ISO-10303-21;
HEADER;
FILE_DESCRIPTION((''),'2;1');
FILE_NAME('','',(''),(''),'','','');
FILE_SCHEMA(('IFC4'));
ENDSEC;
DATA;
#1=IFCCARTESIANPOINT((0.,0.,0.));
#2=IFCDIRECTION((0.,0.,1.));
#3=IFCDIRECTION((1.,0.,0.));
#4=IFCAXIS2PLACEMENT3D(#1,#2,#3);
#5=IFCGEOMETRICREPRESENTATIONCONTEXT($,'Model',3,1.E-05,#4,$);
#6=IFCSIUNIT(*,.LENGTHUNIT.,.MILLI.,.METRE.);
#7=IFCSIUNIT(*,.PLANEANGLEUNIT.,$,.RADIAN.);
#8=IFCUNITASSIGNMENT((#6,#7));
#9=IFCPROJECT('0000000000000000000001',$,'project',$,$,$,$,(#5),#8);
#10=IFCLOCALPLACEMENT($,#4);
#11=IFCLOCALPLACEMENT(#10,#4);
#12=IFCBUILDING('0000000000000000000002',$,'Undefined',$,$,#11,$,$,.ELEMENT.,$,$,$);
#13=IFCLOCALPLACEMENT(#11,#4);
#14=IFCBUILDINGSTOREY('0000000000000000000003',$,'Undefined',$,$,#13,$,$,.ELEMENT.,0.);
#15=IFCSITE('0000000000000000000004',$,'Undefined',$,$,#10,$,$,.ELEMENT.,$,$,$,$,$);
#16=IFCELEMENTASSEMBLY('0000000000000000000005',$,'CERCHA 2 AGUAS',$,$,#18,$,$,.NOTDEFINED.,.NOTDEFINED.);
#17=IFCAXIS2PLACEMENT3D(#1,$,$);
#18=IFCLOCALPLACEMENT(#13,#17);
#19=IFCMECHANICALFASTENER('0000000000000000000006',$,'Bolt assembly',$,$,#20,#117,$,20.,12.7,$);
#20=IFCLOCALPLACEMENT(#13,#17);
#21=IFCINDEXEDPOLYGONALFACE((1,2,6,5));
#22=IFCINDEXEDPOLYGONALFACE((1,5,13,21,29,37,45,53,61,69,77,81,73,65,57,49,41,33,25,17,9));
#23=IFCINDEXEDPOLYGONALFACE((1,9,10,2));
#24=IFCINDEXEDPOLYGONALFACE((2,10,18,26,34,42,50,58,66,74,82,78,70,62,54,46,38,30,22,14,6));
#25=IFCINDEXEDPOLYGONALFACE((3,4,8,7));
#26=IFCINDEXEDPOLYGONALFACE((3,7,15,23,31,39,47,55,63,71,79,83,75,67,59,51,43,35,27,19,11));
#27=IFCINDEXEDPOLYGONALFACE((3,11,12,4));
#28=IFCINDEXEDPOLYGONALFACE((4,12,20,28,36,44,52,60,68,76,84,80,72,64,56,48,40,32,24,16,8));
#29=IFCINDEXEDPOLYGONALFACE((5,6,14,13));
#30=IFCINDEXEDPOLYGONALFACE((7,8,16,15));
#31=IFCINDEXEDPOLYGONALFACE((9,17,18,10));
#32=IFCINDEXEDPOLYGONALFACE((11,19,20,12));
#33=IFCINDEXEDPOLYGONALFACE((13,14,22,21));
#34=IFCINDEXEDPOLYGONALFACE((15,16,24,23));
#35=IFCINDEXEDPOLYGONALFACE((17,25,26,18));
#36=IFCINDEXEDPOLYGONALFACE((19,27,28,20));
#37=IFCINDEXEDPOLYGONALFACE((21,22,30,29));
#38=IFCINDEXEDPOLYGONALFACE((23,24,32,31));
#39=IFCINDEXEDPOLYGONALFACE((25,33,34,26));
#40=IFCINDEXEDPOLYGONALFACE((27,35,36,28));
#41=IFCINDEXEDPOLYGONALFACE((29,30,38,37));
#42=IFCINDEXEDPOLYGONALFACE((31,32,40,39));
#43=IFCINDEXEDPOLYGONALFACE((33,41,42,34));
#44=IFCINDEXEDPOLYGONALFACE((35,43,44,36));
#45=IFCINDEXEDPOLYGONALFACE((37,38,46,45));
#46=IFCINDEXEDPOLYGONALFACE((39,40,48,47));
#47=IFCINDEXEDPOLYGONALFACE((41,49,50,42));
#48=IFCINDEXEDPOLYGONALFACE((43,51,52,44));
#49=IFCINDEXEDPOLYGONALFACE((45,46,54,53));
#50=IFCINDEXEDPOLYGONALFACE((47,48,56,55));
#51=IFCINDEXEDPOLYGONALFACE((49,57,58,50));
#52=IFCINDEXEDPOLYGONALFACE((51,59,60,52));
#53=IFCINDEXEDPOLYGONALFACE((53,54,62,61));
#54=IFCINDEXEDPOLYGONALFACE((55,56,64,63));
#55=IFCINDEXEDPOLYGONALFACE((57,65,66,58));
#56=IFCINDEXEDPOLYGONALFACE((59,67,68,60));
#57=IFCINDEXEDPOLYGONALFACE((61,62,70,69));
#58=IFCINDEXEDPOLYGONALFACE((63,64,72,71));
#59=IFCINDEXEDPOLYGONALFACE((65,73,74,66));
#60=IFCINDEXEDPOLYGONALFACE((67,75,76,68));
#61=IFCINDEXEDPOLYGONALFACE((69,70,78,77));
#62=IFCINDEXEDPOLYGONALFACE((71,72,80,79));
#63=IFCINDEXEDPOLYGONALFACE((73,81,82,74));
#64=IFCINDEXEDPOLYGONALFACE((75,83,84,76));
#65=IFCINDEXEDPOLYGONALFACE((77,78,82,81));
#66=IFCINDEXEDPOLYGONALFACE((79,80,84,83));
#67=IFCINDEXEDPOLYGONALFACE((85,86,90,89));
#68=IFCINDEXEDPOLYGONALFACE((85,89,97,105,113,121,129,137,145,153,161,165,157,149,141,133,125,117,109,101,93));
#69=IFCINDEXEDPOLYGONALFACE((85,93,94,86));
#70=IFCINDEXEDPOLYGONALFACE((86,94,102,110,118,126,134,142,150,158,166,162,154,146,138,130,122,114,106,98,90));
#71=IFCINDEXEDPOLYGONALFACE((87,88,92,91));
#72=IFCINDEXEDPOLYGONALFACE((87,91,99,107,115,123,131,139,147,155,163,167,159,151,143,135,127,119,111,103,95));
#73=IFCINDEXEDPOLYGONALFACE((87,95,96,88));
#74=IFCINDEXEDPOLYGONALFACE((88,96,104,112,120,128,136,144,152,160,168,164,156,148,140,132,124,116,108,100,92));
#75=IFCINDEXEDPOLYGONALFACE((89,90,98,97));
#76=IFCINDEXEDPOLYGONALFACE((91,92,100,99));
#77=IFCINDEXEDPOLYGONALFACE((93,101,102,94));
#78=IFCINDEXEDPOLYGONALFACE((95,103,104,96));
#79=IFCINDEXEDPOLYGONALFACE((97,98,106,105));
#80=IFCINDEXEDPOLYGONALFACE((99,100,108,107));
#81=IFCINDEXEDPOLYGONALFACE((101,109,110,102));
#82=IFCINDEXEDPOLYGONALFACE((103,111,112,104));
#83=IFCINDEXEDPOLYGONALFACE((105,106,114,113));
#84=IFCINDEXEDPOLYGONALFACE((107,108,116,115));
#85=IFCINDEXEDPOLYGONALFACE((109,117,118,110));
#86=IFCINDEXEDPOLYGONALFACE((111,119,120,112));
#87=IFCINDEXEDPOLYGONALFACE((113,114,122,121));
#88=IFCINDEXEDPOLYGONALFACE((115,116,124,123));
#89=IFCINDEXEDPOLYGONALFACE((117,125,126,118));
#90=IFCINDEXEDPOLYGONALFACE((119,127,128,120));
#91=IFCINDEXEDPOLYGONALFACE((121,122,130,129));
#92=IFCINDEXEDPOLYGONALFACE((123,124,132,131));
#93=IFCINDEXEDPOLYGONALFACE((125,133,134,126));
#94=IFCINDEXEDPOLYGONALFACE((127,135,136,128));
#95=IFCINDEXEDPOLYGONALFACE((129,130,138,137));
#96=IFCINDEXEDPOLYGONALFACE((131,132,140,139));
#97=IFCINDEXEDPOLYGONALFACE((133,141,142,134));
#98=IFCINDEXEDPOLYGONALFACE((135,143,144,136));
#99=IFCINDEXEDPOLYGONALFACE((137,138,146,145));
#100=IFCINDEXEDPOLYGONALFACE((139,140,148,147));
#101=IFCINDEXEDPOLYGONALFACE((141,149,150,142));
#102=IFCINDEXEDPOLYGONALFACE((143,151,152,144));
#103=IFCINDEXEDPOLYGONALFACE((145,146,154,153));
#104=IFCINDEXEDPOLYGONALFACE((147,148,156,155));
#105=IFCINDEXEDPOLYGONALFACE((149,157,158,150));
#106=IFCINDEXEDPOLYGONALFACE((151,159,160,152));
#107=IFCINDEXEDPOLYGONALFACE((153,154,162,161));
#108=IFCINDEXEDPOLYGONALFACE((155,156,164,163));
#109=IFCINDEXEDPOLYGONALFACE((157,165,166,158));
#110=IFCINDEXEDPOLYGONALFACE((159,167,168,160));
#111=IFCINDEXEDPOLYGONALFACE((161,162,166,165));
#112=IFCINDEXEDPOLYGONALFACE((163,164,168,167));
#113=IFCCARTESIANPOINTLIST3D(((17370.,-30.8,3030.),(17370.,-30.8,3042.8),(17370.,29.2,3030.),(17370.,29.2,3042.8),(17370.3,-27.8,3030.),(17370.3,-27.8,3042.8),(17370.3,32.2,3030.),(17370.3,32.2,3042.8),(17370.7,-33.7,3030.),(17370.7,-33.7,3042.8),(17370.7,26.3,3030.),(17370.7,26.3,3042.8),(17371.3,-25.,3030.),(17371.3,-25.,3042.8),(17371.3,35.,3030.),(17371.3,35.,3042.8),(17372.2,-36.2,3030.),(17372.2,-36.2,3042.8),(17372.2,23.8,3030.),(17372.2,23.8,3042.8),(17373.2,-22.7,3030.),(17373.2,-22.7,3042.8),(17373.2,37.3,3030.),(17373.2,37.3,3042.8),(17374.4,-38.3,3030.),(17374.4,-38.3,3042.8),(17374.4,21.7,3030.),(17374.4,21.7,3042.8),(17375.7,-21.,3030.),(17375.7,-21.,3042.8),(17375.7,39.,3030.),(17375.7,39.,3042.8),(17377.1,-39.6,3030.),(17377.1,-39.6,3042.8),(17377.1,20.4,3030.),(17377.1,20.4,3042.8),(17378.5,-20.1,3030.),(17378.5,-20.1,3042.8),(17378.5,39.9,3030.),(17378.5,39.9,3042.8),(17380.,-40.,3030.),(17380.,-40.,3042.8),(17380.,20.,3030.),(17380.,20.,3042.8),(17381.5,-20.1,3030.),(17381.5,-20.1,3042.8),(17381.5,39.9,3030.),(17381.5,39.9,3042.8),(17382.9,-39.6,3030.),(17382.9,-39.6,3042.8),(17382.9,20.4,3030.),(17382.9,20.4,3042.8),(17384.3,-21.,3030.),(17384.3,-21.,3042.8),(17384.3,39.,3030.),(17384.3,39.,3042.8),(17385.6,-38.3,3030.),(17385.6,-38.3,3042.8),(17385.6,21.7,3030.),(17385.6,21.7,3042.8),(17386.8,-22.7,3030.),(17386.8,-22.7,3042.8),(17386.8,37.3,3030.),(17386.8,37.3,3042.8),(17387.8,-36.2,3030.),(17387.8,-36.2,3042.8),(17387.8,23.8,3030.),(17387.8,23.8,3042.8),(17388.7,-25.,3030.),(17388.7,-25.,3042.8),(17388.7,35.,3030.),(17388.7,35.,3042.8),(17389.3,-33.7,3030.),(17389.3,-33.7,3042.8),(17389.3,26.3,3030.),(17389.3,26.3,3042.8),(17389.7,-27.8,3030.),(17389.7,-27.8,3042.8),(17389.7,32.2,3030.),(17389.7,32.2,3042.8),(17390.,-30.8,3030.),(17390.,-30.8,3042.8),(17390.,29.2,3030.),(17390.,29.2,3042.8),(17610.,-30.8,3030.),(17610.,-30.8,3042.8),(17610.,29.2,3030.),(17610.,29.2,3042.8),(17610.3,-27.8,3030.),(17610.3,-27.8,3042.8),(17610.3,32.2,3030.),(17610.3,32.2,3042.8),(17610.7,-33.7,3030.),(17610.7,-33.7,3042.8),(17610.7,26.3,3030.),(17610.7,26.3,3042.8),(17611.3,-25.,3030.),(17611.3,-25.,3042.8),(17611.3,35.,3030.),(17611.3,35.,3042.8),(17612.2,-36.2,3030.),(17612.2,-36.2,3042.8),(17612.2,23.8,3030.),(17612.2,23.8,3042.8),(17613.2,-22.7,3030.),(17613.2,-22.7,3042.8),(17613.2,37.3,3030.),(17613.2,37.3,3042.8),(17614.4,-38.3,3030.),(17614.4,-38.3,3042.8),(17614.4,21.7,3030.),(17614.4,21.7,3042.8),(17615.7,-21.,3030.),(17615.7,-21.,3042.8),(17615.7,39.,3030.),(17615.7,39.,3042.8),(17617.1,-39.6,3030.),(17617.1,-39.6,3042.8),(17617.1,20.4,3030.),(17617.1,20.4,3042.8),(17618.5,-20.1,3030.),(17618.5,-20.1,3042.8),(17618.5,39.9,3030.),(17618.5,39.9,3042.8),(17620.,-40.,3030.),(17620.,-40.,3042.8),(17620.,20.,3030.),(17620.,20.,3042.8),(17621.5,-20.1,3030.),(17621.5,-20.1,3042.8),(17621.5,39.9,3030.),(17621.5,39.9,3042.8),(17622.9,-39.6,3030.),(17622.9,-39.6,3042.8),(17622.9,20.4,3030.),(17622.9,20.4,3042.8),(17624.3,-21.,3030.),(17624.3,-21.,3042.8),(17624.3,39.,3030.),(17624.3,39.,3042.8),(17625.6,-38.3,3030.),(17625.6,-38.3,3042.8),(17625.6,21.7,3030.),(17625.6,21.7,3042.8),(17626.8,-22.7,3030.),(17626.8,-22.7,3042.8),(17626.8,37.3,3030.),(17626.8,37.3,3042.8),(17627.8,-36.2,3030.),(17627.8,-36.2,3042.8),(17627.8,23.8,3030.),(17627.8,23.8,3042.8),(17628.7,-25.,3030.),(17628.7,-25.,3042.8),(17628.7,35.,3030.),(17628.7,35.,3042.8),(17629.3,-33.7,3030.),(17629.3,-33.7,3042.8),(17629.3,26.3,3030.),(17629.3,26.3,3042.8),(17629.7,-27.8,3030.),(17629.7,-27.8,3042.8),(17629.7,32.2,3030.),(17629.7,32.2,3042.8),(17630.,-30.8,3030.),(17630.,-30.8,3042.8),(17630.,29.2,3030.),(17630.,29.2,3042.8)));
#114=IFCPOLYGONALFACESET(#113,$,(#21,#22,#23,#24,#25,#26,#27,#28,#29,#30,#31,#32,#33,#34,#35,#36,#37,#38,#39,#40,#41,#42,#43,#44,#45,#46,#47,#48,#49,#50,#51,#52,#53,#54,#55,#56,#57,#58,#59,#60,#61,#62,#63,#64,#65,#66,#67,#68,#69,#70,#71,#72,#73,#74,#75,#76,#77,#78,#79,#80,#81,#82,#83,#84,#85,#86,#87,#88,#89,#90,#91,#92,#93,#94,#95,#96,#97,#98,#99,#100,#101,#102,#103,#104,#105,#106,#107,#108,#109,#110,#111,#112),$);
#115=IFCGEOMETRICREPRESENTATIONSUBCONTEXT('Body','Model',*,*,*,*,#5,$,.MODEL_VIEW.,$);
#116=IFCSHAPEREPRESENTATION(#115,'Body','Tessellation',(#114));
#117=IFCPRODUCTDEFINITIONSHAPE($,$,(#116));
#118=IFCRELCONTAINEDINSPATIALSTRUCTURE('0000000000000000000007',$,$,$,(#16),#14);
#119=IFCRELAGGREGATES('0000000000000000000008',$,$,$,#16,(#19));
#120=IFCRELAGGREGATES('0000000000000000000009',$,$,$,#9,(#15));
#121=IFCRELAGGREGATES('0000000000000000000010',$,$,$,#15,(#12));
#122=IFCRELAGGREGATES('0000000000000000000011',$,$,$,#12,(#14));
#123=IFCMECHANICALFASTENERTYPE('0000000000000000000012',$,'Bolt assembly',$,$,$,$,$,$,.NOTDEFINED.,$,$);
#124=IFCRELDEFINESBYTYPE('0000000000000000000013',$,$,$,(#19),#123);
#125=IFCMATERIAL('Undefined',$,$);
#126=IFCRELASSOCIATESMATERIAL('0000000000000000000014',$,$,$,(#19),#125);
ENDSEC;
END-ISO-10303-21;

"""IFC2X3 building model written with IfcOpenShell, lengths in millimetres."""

from ifc_helpers import new_model, si_unit, frame, origin_with_axes, origin_2d_with_axis, place, context, subcontext, project, spatial, circle, extrude, source, transform, mapped, material, type_object, element, aggregate, save


model = new_model("IFC2X3")

# Units and contexts
model_context = context("Model", 3, precision=1e-05, world=origin_with_axes())
body_context = subcontext(model_context, "Body", "Model", "MODEL_VIEW")
ifc_project = project(units=[si_unit("LENGTHUNIT", "METRE", prefix="MILLI"), si_unit("PLANEANGLEUNIT", "RADIAN")], contexts=[model_context])

# Site, building, storey
site_placement = place(None, origin_with_axes())
site = spatial("IfcSite", under=ifc_project, at=site_placement, Name="Undefined", CompositionType="ELEMENT")
building_placement = place(site_placement, origin_with_axes())
building = spatial("IfcBuilding", under=site, at=building_placement, Name="Undefined", CompositionType="ELEMENT")
storey_placement = place(building_placement, origin_with_axes())
storey = spatial("IfcBuildingStorey", under=building, at=storey_placement, Name="Undefined", CompositionType="ELEMENT", Elevation=0.0)

# Element assembly
assembly_1_placement = place(storey_placement, origin_with_axes())
assembly_1 = element("IfcElementAssembly", 1, at=assembly_1_placement, inside=storey, Name="CERCHA 2 AGUAS", AssemblyPlace="NOTDEFINED", PredefinedType="NOTDEFINED")

# Shared definitions
ifc_material_1 = material(Name="Undefined")
mechanical_fastener_type = type_object("IfcMechanicalFastenerType", Name="Bolt assembly")

# Mechanical fastener
shared_shape_1 = source(origin_with_axes(), body_context, "Body", "SweptSolid", [
    extrude(circle(Radius=10.0, at=origin_2d_with_axis()), frame((0.0, -12.7, 0.0), z_axis=(0.0, 1.0, 0.0), x_axis=(1.0, 0.0, 0.0)), (0.0, 0.0, 1.0), 12.8),
])
mechanical_fastener_1_placement = place(assembly_1_placement, frame((17500.0, 30.0, 3042.7), z_axis=(-1.0, 0.0, 0.0), x_axis=(0.0, -1.0, 0.0)))
mechanical_fastener_1 = element("IfcMechanicalFastener", 2, at=mechanical_fastener_1_placement, type_object=mechanical_fastener_type, material=ifc_material_1, Name="Bolt assembly", NominalDiameter=20.0, NominalLength=12.7, context=body_context, shape_type="MappedRepresentation", body=[
    mapped(shared_shape_1, transform((0.0, 0.0, -120.0))),
    mapped(shared_shape_1, transform((60.0, 0.0, -120.0))),
    mapped(shared_shape_1, transform((0.0, 0.0, 120.0))),
    mapped(shared_shape_1, transform((60.0, 0.0, 120.0))),
])
aggregate(assembly_1, [mechanical_fastener_1])

save(model, "model.ifc")
